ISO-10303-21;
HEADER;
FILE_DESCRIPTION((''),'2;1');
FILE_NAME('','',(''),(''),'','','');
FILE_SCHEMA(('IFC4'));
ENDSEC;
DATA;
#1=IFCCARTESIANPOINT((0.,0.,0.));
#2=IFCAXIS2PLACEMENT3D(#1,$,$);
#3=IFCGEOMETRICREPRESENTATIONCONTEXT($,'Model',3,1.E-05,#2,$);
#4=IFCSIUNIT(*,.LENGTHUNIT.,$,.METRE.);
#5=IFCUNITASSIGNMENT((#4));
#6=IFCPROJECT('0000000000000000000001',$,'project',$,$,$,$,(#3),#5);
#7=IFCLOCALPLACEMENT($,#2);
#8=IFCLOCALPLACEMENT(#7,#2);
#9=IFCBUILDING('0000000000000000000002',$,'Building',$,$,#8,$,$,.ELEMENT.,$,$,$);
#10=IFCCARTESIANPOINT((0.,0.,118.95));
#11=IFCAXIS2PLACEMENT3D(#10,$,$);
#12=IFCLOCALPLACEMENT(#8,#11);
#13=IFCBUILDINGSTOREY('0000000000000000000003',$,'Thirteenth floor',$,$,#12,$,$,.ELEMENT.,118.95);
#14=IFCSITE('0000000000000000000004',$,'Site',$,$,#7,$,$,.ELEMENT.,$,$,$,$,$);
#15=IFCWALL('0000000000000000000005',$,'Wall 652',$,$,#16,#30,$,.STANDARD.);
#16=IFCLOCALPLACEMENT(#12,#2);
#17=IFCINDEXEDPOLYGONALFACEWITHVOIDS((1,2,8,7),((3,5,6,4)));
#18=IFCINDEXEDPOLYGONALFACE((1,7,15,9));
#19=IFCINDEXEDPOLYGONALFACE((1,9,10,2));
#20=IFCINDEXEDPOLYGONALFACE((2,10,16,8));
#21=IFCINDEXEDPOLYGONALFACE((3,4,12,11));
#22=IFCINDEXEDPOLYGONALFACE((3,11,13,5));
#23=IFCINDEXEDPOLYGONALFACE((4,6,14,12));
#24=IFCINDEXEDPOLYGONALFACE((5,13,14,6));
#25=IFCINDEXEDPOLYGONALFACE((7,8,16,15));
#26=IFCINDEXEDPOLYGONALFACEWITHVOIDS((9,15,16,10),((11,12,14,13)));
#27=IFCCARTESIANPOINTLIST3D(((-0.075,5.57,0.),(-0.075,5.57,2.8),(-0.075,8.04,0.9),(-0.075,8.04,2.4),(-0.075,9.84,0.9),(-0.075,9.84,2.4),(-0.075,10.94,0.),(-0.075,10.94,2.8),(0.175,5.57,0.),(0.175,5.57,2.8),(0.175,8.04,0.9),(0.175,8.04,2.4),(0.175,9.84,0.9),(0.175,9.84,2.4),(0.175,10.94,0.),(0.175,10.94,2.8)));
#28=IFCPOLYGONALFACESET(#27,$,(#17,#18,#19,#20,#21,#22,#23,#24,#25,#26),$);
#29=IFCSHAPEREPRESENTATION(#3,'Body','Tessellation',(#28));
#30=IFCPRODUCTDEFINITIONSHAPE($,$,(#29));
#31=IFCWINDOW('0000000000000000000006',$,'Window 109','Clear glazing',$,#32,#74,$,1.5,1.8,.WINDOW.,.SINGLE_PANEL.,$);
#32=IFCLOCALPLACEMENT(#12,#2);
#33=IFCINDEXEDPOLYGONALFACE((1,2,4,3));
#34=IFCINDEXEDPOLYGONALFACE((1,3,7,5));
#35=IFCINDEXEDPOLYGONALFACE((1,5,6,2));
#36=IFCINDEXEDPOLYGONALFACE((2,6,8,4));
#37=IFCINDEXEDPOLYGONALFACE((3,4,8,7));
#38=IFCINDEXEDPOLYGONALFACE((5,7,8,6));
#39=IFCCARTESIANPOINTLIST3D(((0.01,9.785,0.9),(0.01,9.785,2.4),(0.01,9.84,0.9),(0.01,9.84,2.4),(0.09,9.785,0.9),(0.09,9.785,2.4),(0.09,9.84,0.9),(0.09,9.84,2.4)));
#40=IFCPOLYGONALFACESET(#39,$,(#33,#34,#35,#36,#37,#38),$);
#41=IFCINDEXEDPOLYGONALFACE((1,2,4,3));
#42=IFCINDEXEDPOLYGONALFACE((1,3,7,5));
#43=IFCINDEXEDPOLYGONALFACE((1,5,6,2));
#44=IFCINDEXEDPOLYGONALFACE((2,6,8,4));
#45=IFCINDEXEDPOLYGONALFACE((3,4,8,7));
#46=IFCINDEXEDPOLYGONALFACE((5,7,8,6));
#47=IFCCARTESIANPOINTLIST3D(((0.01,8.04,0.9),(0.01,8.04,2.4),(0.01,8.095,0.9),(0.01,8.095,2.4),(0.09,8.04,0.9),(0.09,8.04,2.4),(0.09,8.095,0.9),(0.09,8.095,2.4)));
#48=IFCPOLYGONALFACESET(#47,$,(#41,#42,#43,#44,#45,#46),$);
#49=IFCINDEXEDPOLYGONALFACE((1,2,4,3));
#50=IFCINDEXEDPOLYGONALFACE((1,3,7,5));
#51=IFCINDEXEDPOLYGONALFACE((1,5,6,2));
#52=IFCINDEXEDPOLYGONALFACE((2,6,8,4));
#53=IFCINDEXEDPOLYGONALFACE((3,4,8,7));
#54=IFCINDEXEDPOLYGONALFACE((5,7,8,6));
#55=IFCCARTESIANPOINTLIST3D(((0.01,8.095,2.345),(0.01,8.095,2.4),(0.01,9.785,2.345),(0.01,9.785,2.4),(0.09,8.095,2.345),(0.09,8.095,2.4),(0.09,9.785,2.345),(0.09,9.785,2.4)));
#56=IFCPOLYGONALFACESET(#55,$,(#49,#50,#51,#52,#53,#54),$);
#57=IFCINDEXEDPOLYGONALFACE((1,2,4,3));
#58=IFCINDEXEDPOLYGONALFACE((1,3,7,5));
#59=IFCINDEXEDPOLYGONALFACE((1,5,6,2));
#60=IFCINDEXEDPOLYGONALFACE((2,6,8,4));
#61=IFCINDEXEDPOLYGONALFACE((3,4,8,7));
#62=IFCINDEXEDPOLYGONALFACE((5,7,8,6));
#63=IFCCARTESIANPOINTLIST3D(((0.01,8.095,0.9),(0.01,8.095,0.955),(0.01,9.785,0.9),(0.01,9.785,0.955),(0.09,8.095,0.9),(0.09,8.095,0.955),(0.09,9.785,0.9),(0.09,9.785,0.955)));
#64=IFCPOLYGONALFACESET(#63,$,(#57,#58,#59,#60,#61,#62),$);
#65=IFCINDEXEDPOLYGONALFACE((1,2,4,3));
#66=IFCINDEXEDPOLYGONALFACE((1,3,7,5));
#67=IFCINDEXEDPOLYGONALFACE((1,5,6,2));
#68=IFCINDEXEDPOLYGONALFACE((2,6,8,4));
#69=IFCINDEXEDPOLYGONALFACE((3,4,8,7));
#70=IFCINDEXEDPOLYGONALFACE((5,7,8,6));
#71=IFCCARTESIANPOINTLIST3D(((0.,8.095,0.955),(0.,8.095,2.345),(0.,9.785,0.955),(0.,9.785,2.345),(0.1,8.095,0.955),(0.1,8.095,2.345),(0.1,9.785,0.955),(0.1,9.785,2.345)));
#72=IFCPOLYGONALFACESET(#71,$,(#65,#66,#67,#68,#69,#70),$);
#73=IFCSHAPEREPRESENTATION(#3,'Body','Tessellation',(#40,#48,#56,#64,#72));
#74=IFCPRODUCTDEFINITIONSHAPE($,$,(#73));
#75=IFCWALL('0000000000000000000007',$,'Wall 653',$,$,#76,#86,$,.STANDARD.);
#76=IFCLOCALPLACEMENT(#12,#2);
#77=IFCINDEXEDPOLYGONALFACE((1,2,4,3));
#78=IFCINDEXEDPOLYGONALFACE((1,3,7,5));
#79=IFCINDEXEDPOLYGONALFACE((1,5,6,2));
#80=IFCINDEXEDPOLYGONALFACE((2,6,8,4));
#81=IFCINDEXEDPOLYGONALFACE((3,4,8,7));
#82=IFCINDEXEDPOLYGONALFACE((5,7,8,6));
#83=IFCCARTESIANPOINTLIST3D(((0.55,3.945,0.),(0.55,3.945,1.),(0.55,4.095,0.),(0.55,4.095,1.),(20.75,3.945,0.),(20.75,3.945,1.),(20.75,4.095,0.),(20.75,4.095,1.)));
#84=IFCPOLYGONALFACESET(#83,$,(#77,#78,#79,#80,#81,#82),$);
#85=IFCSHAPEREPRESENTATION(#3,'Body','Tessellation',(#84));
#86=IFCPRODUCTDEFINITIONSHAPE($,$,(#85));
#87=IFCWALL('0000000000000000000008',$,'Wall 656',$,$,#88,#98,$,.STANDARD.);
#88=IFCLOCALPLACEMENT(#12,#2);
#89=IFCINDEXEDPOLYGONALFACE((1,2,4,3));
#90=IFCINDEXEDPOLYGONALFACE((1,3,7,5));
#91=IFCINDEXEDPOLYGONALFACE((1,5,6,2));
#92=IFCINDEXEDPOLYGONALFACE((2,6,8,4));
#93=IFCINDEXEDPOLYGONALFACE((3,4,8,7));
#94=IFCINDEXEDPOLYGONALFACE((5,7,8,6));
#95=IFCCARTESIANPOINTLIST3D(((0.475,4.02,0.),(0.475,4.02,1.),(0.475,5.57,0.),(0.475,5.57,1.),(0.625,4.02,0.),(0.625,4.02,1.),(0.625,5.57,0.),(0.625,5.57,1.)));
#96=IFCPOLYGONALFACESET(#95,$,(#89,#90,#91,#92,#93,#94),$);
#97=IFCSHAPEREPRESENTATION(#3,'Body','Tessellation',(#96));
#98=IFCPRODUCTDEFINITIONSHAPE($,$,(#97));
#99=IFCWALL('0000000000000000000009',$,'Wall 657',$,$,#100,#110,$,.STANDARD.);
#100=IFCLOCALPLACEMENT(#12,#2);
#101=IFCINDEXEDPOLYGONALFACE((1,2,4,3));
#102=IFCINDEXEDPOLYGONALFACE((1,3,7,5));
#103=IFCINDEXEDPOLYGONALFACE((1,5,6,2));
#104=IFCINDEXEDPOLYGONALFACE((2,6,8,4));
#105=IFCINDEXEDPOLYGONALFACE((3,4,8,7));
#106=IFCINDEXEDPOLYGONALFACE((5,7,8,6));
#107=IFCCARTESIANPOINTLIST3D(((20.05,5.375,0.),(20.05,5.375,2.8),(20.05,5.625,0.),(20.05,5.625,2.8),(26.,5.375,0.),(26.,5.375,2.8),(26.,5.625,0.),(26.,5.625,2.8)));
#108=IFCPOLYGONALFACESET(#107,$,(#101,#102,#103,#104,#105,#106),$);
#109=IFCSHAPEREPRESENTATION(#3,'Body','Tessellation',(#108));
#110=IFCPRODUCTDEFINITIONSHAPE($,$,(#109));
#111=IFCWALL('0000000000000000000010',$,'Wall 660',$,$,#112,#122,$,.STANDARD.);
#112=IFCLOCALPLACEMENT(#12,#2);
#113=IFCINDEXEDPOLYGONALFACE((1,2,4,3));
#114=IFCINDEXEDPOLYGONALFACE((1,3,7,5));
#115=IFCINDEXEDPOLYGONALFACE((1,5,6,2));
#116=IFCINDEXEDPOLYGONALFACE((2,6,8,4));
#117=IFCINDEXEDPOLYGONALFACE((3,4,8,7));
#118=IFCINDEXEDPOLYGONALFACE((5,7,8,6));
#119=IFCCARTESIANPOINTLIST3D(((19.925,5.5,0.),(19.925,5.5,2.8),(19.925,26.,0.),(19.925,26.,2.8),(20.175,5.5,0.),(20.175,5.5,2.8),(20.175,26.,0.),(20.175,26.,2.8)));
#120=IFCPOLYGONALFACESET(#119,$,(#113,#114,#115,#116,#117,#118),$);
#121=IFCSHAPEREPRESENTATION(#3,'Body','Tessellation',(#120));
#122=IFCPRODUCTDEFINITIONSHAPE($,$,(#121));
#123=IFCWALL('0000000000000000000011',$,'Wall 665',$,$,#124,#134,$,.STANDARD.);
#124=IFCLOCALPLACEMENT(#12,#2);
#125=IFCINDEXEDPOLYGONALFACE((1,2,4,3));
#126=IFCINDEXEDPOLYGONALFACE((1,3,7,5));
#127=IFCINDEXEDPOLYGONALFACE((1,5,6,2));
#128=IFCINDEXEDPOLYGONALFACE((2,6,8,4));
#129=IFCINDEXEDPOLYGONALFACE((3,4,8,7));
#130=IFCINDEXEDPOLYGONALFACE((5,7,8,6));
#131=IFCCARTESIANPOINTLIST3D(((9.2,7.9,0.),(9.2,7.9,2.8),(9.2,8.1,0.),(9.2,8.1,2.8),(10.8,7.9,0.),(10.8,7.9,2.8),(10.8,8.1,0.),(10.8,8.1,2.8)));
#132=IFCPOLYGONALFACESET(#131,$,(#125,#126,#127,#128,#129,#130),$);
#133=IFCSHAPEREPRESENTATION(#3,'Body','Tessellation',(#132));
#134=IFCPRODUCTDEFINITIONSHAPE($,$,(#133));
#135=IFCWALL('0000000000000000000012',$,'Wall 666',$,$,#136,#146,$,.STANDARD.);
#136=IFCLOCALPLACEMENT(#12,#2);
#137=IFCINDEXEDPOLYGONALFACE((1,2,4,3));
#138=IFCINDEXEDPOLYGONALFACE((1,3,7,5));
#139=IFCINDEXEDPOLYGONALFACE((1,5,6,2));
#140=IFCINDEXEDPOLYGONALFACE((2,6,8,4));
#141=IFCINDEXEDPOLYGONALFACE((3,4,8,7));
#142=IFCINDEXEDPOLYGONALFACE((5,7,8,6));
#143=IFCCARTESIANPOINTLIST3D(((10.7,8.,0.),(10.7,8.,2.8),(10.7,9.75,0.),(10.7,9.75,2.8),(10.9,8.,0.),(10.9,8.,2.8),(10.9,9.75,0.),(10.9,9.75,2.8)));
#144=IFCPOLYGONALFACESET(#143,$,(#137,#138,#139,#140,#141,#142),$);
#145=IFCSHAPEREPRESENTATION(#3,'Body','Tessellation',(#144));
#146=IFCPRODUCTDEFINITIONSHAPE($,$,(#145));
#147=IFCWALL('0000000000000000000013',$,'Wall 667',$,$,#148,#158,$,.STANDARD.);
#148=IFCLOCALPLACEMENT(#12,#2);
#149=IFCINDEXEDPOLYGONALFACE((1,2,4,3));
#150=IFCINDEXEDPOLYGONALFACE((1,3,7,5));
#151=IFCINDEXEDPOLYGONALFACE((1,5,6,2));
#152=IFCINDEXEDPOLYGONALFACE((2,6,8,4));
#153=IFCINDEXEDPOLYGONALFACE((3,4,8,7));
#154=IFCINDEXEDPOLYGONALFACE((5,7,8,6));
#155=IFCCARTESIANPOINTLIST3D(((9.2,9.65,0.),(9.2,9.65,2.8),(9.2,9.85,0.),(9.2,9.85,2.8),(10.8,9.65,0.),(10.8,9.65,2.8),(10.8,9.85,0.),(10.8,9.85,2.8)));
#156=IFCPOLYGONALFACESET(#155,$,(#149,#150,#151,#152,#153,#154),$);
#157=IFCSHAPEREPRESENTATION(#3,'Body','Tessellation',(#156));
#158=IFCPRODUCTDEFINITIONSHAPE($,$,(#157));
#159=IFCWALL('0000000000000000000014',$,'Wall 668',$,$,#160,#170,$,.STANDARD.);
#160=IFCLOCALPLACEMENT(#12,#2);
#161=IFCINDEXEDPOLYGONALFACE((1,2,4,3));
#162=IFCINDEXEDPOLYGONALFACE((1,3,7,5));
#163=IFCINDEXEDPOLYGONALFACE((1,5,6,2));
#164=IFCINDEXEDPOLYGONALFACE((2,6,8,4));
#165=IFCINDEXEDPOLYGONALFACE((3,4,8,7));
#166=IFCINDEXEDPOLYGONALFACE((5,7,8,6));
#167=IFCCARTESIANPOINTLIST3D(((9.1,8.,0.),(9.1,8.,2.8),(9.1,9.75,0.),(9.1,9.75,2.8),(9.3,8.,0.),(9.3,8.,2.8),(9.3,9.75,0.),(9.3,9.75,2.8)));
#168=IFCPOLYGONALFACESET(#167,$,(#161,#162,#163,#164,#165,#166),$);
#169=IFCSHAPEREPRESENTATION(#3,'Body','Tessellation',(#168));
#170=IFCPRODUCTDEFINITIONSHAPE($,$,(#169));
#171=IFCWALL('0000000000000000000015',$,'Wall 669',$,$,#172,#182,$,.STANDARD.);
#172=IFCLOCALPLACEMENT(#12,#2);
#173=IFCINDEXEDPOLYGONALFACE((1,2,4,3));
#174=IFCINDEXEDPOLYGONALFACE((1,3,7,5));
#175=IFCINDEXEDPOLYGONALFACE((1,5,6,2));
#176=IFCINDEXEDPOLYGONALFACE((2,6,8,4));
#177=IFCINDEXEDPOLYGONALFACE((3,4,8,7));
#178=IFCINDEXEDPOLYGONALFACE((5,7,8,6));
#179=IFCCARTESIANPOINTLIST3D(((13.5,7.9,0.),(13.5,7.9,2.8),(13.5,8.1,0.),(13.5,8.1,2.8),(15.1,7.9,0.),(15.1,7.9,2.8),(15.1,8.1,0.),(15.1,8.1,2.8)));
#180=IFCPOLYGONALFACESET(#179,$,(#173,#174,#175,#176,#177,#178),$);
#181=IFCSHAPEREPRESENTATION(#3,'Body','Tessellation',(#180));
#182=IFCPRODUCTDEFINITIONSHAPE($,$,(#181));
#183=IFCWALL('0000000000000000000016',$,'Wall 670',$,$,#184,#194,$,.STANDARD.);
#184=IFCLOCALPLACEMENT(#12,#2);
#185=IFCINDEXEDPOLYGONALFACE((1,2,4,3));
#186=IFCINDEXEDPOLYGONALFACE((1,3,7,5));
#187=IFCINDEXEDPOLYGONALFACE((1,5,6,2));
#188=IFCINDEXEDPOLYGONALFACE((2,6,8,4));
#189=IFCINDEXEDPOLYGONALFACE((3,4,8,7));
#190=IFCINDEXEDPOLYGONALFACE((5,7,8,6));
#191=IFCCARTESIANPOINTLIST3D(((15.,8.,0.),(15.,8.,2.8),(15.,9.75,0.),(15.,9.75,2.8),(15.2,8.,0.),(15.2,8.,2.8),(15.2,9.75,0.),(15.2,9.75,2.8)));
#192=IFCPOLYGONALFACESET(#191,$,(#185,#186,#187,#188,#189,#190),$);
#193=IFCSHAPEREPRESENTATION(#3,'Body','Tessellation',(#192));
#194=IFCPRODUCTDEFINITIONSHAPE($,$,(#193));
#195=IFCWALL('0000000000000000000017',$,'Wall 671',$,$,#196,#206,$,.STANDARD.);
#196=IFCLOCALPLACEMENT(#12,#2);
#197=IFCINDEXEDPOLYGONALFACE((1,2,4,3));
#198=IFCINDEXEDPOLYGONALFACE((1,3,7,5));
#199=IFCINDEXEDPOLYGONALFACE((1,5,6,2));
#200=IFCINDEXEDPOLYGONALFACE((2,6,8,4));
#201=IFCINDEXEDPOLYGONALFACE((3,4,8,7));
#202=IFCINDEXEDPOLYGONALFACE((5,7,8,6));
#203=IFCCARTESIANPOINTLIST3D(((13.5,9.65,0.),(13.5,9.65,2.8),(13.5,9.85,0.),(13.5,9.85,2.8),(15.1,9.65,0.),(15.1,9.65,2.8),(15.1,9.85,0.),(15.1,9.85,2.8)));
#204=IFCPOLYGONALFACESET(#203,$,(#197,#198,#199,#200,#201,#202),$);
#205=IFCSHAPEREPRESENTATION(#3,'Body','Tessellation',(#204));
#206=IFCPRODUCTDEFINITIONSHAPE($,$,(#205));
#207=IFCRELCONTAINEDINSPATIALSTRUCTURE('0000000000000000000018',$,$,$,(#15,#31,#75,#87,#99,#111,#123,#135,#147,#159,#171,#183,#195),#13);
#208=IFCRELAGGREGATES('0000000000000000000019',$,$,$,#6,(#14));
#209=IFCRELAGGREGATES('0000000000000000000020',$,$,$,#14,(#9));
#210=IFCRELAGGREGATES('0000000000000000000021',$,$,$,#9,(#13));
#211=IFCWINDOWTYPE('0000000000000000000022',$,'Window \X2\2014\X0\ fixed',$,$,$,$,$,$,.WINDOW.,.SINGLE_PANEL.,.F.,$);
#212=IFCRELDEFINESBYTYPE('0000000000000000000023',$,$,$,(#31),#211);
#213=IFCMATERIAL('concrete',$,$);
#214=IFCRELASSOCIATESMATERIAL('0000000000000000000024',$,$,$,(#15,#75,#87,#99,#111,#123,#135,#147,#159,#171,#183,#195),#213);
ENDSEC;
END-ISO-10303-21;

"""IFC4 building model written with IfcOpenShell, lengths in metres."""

from ifc_helpers import new_model, si_unit, frame, frame_2d, origin, place, context, project, spatial, rectangle, extrude, material, type_object, element, fill, save


model = new_model("IFC4")

# Units and contexts
model_context = context("Model", 3, precision=1e-05, world=origin())
ifc_project = project(units=[si_unit("LENGTHUNIT", "METRE")], contexts=[model_context])

# Site, building, storey
site_placement = place(None, origin())
site = spatial("IfcSite", under=ifc_project, at=site_placement, Name="Site", CompositionType="ELEMENT")
building_placement = place(site_placement, origin())
building = spatial("IfcBuilding", under=site, at=building_placement, Name="Building", CompositionType="ELEMENT")
storey_placement = place(building_placement, frame((0.0, 0.0, 118.95)))
storey = spatial("IfcBuildingStorey", under=building, at=storey_placement, Name="Thirteenth floor", CompositionType="ELEMENT", Elevation=118.95)

# Shared definitions
ifc_material = material(Name="concrete")

# Shared definitions
window_type = type_object("IfcWindowType", Name="Window — fixed", ParameterTakesPrecedence=False, PartitioningType="SINGLE_PANEL", PredefinedType="WINDOW")

# Wall, opening, window
wall_1_placement = place(storey_placement, frame((0.05, 10.94, 0.0), z_axis=(0.0, 0.0, 1.0), x_axis=(0.0, -1.0, 0.0)))
wall_1 = element("IfcWall", 1, at=wall_1_placement, inside=storey, material=ifc_material, Name="Wall 652", PredefinedType="STANDARD", context=model_context, shape_type="SweptSolid", body=[
    extrude(rectangle(XDim=5.37, YDim=0.25, at=frame_2d((2.685, 0.0))), origin(), (0.0, 0.0, 1.0), 2.8),
])
opening_1_placement = place(storey_placement, frame((0.05, 9.84, 0.9), z_axis=(0.0, 0.0, 1.0), x_axis=(0.0, -1.0, 0.0)))
opening_1 = element("IfcOpeningElement", 2, at=opening_1_placement, cuts=wall_1, PredefinedType="OPENING", context=model_context, shape_type="SweptSolid", body=[
    extrude(rectangle(XDim=1.8, YDim=0.31, at=frame_2d((0.9, 0.0))), origin(), (0.0, 0.0, 1.0), 1.5),
])
window_1_placement = place(storey_placement, frame((0.05, 9.84, 0.9), z_axis=(0.0, 0.0, 1.0), x_axis=(0.0, -1.0, 0.0)))
window_1 = element("IfcWindow", 3, at=window_1_placement, inside=storey, type_object=window_type, Name="Window 109", Description="Clear glazing", OverallHeight=1.5, OverallWidth=1.8, PartitioningType="SINGLE_PANEL", PredefinedType="WINDOW", context=model_context, shape_type="SweptSolid", body=[
    extrude(rectangle(XDim=0.055, YDim=0.08, at=frame_2d((0.0275, 0.0))), origin(), (0.0, 0.0, 1.0), 1.5),
    extrude(rectangle(XDim=0.055, YDim=0.08, at=frame_2d((1.7725, 0.0))), origin(), (0.0, 0.0, 1.0), 1.5),
    extrude(rectangle(XDim=1.69, YDim=0.08, at=frame_2d((0.9, 0.0))), frame((0.0, 0.0, 1.445)), (0.0, 0.0, 1.0), 0.055),
    extrude(rectangle(XDim=1.69, YDim=0.08, at=frame_2d((0.9, 0.0))), origin(), (0.0, 0.0, 1.0), 0.055),
    extrude(rectangle(XDim=1.69, YDim=0.1, at=frame_2d((0.9, 0.0))), frame((0.0, 0.0, 0.055)), (0.0, 0.0, 1.0), 1.39),
])
fill(opening_1, window_1)

# Walls
wall_2_placement = place(storey_placement, frame((0.55, 4.02, 0.0), z_axis=(0.0, 0.0, 1.0), x_axis=(1.0, 0.0, 0.0)))
element("IfcWall", 4, at=wall_2_placement, inside=storey, material=ifc_material, Name="Wall 653", PredefinedType="STANDARD", context=model_context, shape_type="SweptSolid", body=[
    extrude(rectangle(XDim=20.2, YDim=0.15, at=frame_2d((10.1, 0.0))), origin(), (0.0, 0.0, 1.0), 1.0),
])
wall_3_placement = place(storey_placement, frame((0.55, 5.57, 0.0), z_axis=(0.0, 0.0, 1.0), x_axis=(0.0, -1.0, 0.0)))
element("IfcWall", 5, at=wall_3_placement, inside=storey, material=ifc_material, Name="Wall 656", PredefinedType="STANDARD", context=model_context, shape_type="SweptSolid", body=[
    extrude(rectangle(XDim=1.55, YDim=0.15, at=frame_2d((0.775, 0.0))), origin(), (0.0, 0.0, 1.0), 1.0),
])
wall_4_placement = place(storey_placement, frame((20.05, 5.5, 0.0), z_axis=(0.0, 0.0, 1.0), x_axis=(1.0, 0.0, 0.0)))
element("IfcWall", 6, at=wall_4_placement, inside=storey, material=ifc_material, Name="Wall 657", PredefinedType="STANDARD", context=model_context, shape_type="SweptSolid", body=[
    extrude(rectangle(XDim=5.95, YDim=0.25, at=frame_2d((2.975, 0.0))), origin(), (0.0, 0.0, 1.0), 2.8),
])
wall_5_placement = place(storey_placement, frame((20.05, 26.0, 0.0), z_axis=(0.0, 0.0, 1.0), x_axis=(0.0, -1.0, 0.0)))
element("IfcWall", 7, at=wall_5_placement, inside=storey, material=ifc_material, Name="Wall 660", PredefinedType="STANDARD", context=model_context, shape_type="SweptSolid", body=[
    extrude(rectangle(XDim=20.5, YDim=0.25, at=frame_2d((10.25, 0.0))), origin(), (0.0, 0.0, 1.0), 2.8),
])
wall_6_placement = place(storey_placement, frame((9.2, 8.0, 0.0), z_axis=(0.0, 0.0, 1.0), x_axis=(1.0, 0.0, 0.0)))
element("IfcWall", 8, at=wall_6_placement, inside=storey, material=ifc_material, Name="Wall 665", PredefinedType="STANDARD", context=model_context, shape_type="SweptSolid", body=[
    extrude(rectangle(XDim=1.6, YDim=0.2, at=frame_2d((0.8, 0.0))), origin(), (0.0, 0.0, 1.0), 2.8),
])
wall_7_placement = place(storey_placement, frame((10.8, 8.0, 0.0), z_axis=(0.0, 0.0, 1.0), x_axis=(0.0, 1.0, 0.0)))
element("IfcWall", 9, at=wall_7_placement, inside=storey, material=ifc_material, Name="Wall 666", PredefinedType="STANDARD", context=model_context, shape_type="SweptSolid", body=[
    extrude(rectangle(XDim=1.75, YDim=0.2, at=frame_2d((0.875, 0.0))), origin(), (0.0, 0.0, 1.0), 2.8),
])
wall_8_placement = place(storey_placement, frame((10.8, 9.75, 0.0), z_axis=(0.0, 0.0, 1.0), x_axis=(-1.0, 0.0, 0.0)))
element("IfcWall", 10, at=wall_8_placement, inside=storey, material=ifc_material, Name="Wall 667", PredefinedType="STANDARD", context=model_context, shape_type="SweptSolid", body=[
    extrude(rectangle(XDim=1.6, YDim=0.2, at=frame_2d((0.8, 0.0))), origin(), (0.0, 0.0, 1.0), 2.8),
])
wall_9_placement = place(storey_placement, frame((9.2, 9.75, 0.0), z_axis=(0.0, 0.0, 1.0), x_axis=(0.0, -1.0, 0.0)))
element("IfcWall", 11, at=wall_9_placement, inside=storey, material=ifc_material, Name="Wall 668", PredefinedType="STANDARD", context=model_context, shape_type="SweptSolid", body=[
    extrude(rectangle(XDim=1.75, YDim=0.2, at=frame_2d((0.875, 0.0))), origin(), (0.0, 0.0, 1.0), 2.8),
])
wall_10_placement = place(storey_placement, frame((13.5, 8.0, 0.0), z_axis=(0.0, 0.0, 1.0), x_axis=(1.0, 0.0, 0.0)))
element("IfcWall", 12, at=wall_10_placement, inside=storey, material=ifc_material, Name="Wall 669", PredefinedType="STANDARD", context=model_context, shape_type="SweptSolid", body=[
    extrude(rectangle(XDim=1.6, YDim=0.2, at=frame_2d((0.8, 0.0))), origin(), (0.0, 0.0, 1.0), 2.8),
])
wall_11_placement = place(storey_placement, frame((15.1, 8.0, 0.0), z_axis=(0.0, 0.0, 1.0), x_axis=(0.0, 1.0, 0.0)))
element("IfcWall", 13, at=wall_11_placement, inside=storey, material=ifc_material, Name="Wall 670", PredefinedType="STANDARD", context=model_context, shape_type="SweptSolid", body=[
    extrude(rectangle(XDim=1.75, YDim=0.2, at=frame_2d((0.875, 0.0))), origin(), (0.0, 0.0, 1.0), 2.8),
])
wall_12_placement = place(storey_placement, frame((15.1, 9.75, 0.0), z_axis=(0.0, 0.0, 1.0), x_axis=(-1.0, 0.0, 0.0)))
element("IfcWall", 14, at=wall_12_placement, inside=storey, material=ifc_material, Name="Wall 671", PredefinedType="STANDARD", context=model_context, shape_type="SweptSolid", body=[
    extrude(rectangle(XDim=1.6, YDim=0.2, at=frame_2d((0.8, 0.0))), origin(), (0.0, 0.0, 1.0), 2.8),
])

save(model, "model.ifc")
